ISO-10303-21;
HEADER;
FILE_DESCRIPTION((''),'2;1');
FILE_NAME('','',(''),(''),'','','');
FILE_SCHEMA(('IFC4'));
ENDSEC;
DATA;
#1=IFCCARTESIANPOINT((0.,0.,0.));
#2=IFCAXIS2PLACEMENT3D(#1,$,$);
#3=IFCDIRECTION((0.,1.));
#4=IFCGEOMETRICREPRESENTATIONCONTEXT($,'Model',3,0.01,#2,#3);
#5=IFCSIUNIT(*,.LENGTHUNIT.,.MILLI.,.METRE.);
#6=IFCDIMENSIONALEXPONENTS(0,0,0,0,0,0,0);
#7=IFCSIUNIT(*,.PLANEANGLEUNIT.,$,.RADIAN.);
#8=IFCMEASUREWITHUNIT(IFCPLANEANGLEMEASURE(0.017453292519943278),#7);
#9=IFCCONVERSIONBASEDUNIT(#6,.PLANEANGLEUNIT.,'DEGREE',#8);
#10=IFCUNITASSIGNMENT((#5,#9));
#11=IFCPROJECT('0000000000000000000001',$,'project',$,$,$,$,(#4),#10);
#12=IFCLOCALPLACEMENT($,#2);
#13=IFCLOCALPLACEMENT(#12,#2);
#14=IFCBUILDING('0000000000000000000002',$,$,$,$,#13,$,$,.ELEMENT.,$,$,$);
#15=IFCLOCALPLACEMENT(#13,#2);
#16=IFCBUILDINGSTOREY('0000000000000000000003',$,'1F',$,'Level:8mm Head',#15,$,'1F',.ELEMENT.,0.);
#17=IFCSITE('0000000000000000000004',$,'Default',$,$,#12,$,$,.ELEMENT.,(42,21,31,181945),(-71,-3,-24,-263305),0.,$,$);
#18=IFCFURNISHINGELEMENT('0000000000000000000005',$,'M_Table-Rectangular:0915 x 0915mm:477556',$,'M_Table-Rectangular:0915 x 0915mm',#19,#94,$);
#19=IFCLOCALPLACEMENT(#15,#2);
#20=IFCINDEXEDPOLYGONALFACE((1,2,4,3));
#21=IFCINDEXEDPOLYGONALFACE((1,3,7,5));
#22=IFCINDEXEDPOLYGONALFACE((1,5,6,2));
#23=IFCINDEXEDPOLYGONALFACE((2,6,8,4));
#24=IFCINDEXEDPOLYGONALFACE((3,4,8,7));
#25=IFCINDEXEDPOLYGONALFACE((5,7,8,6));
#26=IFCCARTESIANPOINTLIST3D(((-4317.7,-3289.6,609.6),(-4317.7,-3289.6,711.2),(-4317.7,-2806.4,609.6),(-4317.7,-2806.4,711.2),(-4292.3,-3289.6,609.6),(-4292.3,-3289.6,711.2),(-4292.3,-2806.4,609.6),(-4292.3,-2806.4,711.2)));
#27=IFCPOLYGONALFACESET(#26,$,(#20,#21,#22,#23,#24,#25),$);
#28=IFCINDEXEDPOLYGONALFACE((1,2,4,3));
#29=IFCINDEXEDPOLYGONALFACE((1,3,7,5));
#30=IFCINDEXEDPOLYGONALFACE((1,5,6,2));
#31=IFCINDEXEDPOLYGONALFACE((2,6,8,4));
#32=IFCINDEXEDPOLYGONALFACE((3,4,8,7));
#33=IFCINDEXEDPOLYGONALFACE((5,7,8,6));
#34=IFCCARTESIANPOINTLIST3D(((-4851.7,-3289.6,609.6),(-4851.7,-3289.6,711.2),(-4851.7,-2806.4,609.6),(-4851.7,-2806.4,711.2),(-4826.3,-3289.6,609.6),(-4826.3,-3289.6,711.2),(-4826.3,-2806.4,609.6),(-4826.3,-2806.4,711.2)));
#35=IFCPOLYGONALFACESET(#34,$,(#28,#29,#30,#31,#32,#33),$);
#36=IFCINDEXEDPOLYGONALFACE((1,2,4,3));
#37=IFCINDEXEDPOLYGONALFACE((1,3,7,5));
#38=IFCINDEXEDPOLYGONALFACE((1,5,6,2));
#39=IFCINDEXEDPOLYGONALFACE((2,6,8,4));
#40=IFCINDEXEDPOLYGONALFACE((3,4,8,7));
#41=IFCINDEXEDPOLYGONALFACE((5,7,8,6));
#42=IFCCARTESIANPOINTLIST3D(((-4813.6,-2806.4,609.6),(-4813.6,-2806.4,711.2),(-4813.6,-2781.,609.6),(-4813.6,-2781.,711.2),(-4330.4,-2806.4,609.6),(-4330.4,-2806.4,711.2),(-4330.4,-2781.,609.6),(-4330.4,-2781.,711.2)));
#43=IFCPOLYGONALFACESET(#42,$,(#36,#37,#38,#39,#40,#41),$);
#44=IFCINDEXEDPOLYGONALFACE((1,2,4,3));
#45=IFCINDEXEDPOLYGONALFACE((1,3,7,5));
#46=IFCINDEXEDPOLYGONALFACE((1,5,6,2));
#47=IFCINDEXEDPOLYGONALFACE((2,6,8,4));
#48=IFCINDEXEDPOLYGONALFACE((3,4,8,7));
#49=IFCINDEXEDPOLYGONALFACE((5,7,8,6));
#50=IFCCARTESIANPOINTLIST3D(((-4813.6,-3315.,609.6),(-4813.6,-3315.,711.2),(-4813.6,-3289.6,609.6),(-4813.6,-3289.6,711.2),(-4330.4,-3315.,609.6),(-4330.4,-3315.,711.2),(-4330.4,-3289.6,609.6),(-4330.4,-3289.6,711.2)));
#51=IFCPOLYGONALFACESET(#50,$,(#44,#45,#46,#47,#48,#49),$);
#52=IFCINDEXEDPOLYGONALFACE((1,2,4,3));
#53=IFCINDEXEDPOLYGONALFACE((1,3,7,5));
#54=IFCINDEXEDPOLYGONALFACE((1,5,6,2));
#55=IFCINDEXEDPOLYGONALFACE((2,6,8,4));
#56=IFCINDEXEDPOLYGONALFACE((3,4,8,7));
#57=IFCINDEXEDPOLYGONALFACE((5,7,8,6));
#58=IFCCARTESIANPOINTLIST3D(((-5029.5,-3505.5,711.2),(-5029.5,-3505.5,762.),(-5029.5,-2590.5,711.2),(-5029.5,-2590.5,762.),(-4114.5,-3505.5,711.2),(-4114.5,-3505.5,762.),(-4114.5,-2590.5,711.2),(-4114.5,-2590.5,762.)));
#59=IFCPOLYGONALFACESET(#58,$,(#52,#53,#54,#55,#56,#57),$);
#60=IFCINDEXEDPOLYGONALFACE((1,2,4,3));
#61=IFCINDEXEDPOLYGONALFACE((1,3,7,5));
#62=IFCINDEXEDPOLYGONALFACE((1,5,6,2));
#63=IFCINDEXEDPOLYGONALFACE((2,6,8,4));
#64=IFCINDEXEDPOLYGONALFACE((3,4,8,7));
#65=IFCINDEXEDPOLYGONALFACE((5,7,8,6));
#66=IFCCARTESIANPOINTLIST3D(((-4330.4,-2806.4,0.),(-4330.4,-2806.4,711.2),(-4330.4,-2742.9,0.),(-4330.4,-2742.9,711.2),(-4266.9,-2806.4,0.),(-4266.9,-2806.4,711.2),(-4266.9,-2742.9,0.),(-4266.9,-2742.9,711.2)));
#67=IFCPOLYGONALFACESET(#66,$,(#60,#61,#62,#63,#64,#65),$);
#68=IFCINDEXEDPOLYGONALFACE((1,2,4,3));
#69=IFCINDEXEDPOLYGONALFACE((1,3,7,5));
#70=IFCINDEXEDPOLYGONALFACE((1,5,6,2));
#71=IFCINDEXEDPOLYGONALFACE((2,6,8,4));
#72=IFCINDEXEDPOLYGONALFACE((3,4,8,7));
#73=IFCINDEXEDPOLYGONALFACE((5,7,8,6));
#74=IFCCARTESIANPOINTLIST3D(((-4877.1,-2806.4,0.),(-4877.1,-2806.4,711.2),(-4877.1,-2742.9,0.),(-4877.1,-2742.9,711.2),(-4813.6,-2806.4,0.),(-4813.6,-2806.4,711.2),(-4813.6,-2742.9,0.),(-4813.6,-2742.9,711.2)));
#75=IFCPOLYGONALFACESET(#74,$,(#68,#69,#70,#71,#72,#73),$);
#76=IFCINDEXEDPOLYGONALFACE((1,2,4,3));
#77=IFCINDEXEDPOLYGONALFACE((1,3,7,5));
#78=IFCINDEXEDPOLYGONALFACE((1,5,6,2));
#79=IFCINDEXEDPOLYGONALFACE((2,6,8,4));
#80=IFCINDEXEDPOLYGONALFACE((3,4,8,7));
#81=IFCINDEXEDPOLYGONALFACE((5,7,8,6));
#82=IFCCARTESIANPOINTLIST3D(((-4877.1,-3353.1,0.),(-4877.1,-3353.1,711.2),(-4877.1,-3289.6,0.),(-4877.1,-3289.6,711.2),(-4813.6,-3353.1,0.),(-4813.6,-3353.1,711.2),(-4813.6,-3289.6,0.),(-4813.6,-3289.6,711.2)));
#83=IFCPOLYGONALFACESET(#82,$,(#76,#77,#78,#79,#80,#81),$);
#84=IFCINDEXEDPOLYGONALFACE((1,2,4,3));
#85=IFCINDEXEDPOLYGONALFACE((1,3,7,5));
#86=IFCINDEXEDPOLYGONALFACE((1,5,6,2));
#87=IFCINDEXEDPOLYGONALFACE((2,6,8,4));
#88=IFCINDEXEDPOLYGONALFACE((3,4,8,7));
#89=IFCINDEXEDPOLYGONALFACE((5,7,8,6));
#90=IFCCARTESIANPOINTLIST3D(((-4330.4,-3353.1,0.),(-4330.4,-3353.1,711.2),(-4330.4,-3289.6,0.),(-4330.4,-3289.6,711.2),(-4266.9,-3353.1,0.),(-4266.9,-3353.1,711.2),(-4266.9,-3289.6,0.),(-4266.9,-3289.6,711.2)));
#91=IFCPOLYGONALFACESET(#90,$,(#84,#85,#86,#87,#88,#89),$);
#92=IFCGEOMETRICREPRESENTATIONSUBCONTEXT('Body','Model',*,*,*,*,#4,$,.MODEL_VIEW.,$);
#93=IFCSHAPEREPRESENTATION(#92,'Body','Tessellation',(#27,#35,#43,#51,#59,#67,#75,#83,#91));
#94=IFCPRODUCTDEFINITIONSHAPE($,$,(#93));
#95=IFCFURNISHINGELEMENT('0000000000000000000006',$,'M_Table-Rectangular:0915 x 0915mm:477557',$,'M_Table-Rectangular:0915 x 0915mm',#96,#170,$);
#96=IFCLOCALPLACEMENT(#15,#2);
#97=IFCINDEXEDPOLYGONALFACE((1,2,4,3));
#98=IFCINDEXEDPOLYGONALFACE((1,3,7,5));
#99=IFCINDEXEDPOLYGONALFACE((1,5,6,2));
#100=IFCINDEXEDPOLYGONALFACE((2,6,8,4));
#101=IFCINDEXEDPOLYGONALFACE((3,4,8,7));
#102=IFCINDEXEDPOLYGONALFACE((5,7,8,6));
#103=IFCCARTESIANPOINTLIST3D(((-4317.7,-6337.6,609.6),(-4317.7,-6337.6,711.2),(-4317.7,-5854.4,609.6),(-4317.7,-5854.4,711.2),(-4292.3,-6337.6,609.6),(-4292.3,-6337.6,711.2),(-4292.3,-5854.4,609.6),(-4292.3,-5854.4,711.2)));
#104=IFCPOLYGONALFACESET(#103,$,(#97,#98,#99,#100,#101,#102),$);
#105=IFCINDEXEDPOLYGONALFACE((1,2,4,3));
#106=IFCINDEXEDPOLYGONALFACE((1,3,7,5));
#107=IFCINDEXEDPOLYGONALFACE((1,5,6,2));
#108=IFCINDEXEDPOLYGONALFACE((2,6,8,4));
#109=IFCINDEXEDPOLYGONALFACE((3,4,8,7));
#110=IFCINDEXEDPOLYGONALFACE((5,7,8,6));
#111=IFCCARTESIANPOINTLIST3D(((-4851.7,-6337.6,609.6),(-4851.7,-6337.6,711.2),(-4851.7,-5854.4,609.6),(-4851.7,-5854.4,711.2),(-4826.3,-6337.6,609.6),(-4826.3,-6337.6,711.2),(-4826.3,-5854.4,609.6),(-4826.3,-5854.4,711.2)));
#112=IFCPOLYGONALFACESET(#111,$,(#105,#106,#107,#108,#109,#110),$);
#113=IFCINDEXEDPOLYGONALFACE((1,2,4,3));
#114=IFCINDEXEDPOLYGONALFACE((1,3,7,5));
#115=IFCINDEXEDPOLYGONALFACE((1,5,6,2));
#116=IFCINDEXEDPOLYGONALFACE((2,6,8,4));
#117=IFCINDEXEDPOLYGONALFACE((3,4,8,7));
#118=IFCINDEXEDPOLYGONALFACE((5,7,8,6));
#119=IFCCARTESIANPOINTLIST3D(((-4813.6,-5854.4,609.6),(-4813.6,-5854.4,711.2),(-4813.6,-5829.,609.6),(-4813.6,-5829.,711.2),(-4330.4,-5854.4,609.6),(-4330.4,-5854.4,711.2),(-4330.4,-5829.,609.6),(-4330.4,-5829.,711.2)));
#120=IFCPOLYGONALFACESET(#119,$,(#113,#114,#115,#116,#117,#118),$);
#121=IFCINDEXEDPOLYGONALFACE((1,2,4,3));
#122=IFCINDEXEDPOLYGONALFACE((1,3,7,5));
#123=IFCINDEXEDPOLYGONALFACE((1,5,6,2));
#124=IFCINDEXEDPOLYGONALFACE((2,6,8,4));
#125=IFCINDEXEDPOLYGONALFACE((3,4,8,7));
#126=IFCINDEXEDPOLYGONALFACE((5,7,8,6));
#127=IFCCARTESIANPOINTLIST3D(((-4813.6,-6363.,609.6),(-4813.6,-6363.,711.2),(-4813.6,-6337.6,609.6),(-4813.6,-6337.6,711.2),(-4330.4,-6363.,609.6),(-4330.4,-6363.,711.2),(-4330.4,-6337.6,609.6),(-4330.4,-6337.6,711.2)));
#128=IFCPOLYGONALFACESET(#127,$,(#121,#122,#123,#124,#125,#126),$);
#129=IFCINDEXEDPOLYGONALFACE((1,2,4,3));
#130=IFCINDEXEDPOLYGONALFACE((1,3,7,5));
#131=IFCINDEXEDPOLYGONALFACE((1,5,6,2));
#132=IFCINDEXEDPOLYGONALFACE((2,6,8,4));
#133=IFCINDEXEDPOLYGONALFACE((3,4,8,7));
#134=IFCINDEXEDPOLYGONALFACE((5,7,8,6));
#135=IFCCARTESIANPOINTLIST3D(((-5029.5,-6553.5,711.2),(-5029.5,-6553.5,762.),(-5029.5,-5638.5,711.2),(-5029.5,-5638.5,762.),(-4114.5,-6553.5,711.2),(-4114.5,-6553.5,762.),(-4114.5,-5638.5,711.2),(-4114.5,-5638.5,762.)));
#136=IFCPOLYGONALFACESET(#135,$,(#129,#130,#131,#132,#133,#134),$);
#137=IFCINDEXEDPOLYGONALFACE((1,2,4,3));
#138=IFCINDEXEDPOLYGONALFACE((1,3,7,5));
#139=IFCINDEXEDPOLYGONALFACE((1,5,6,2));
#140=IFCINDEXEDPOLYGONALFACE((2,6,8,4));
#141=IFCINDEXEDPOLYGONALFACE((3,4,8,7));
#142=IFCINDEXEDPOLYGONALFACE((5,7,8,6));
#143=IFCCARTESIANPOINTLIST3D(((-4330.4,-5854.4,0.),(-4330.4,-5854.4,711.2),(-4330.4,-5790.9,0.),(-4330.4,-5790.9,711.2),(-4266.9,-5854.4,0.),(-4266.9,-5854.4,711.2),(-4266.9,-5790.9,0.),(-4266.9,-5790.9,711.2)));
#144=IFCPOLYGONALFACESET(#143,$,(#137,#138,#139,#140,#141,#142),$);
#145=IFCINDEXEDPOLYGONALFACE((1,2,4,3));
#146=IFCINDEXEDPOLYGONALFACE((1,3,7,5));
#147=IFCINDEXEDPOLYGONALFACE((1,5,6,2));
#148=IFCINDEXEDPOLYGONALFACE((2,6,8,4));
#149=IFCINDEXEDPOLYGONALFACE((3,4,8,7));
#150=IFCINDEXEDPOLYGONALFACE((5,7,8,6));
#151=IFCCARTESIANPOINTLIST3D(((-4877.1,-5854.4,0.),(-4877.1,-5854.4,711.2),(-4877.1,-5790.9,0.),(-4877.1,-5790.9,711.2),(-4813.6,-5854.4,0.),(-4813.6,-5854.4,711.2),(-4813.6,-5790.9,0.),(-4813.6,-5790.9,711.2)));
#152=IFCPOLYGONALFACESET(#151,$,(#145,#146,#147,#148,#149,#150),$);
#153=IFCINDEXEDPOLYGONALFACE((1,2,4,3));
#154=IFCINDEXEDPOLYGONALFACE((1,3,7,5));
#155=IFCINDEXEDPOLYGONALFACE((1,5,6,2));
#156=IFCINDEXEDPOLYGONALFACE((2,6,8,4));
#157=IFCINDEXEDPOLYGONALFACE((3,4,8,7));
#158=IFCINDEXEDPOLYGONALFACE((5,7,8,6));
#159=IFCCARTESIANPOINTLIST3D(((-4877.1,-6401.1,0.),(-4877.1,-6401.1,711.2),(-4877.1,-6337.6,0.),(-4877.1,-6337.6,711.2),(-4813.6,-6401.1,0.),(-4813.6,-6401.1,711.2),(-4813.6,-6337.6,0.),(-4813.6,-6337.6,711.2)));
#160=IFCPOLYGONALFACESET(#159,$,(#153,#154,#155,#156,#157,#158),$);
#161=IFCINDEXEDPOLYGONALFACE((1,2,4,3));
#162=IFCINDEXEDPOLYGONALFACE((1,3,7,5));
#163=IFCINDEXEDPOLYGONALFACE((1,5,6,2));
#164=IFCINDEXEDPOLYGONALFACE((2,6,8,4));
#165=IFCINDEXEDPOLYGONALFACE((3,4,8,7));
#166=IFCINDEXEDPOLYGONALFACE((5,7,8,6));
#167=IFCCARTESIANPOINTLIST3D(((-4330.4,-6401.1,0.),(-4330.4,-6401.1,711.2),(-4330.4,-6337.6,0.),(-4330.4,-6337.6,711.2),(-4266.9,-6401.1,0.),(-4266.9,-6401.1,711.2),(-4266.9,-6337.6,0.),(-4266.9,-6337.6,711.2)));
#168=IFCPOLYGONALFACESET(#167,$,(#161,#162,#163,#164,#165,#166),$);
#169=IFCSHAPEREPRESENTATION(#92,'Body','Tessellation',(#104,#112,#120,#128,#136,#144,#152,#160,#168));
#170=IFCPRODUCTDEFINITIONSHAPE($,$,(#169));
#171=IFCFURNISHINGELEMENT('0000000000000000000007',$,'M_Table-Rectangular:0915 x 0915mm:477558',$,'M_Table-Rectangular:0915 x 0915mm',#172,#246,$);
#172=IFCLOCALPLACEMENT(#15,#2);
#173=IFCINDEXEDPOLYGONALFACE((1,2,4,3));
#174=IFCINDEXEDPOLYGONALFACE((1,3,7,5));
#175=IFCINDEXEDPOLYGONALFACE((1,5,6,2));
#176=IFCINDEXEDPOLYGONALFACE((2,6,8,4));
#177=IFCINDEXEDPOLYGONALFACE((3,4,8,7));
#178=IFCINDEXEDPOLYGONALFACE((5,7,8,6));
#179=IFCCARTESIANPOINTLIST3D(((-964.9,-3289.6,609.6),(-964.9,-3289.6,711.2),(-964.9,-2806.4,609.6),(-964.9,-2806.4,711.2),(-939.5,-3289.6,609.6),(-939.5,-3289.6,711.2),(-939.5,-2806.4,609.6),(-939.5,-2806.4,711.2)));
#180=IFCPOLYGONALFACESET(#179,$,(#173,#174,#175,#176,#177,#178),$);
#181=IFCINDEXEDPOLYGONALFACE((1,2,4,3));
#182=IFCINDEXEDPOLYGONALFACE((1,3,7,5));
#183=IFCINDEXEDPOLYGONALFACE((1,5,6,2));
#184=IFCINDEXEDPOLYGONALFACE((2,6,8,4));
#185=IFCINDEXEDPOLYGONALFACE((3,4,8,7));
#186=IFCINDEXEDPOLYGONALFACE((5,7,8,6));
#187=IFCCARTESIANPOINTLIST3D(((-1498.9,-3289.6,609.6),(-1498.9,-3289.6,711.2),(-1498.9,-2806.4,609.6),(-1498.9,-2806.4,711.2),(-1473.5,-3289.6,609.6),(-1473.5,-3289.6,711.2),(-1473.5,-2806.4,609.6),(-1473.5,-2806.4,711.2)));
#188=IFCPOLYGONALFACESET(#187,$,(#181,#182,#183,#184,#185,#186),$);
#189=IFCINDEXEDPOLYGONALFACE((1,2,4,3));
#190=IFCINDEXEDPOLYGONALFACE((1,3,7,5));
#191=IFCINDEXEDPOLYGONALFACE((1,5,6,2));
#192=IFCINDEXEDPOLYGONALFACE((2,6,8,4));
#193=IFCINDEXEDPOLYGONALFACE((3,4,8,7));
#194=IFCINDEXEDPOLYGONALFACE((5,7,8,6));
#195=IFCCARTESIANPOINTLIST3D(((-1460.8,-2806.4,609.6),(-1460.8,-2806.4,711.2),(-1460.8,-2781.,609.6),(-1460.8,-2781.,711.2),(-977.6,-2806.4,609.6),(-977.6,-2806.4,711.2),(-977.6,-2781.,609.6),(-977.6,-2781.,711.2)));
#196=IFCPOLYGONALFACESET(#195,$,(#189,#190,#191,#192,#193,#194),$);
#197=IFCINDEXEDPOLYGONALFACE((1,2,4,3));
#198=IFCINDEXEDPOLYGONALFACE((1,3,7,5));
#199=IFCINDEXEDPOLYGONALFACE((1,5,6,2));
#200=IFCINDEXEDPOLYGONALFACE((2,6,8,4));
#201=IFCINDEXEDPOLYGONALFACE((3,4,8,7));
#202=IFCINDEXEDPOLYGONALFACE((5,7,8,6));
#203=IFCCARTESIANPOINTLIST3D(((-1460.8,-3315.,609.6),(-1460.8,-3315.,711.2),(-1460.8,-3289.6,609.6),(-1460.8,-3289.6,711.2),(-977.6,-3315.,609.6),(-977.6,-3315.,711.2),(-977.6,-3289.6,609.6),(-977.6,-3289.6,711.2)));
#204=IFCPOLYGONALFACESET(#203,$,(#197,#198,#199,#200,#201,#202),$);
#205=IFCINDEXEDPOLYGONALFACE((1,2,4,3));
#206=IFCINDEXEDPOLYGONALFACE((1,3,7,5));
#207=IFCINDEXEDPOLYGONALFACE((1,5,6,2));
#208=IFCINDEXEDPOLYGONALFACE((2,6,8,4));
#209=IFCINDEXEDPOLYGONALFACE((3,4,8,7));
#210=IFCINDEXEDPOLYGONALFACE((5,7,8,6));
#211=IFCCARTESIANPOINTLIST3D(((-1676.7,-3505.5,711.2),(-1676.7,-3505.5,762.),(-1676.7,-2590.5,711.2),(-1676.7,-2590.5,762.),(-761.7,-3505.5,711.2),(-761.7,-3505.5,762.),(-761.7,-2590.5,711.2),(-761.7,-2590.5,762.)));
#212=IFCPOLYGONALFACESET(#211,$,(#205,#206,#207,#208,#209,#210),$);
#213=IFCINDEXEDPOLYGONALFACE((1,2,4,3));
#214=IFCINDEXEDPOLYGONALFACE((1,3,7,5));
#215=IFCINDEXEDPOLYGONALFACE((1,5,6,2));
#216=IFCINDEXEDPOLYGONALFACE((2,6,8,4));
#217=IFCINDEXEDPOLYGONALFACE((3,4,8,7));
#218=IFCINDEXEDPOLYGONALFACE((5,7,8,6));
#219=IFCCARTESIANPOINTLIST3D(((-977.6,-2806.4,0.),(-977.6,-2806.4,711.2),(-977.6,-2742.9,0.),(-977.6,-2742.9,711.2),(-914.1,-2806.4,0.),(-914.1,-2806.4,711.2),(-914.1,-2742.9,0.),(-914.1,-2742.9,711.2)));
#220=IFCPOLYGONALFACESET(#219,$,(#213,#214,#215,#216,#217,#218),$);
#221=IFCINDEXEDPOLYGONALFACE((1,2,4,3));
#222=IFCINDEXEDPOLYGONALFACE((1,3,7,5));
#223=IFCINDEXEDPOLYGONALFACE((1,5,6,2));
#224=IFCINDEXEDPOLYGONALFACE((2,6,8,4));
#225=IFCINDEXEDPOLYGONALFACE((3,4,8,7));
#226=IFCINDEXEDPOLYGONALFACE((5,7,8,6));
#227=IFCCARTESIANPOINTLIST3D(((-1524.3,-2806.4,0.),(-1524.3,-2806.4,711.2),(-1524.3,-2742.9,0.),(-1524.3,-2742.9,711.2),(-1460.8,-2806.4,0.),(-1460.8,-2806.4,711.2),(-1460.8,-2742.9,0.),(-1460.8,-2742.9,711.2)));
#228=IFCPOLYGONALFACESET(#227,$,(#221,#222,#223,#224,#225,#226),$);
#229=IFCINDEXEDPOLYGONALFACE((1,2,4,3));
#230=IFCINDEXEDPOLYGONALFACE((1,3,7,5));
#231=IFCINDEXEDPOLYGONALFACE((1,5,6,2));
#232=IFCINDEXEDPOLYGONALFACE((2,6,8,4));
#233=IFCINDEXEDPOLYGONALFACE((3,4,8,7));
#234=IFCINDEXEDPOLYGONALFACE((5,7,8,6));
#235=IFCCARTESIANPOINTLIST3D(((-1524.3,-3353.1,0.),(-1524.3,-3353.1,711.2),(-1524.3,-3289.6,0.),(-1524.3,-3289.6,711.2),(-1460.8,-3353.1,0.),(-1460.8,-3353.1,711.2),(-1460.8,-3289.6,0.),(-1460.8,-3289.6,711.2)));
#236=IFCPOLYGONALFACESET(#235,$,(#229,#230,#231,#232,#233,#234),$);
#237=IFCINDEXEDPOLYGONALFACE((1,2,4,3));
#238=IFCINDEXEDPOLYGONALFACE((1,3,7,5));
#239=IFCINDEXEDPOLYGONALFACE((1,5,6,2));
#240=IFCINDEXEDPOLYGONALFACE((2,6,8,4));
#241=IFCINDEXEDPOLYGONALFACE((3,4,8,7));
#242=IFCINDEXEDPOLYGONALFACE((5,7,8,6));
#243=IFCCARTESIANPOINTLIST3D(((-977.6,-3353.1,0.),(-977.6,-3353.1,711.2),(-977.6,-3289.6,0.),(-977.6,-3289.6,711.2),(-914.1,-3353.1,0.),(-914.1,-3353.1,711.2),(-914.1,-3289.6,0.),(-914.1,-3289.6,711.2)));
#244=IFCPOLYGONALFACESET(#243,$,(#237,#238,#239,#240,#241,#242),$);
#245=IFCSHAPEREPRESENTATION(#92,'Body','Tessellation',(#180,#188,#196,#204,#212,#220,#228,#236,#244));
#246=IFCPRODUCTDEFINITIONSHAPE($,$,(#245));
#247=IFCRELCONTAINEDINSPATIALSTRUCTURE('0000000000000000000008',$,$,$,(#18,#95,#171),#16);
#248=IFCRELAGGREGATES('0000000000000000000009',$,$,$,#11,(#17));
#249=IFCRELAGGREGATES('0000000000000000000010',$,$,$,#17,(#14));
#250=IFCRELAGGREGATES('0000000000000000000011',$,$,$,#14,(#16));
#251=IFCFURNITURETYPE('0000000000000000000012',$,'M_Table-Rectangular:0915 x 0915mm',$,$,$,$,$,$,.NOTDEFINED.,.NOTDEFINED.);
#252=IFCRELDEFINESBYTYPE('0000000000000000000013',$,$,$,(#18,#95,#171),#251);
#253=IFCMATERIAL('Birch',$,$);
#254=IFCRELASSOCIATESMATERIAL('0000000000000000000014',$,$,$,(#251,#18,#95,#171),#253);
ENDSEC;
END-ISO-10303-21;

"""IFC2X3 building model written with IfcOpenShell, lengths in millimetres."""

from ifc_helpers import new_model, entity, si_unit, converted_unit, direction, frame, frame_2d, origin, origin_2d_with_axis, place, context, subcontext, project, spatial, rectangle, extrude, source, transform, mapped, material, type_object, type_shapes, element, save


model = new_model("IFC2X3")

# Units and contexts
model_context = context("Model", 3, precision=0.01, world=origin(), true_north=direction((0.0, 1.0)))
body_context = subcontext(model_context, "Body", "Model", "MODEL_VIEW")
ifc_project = project(units=[si_unit("LENGTHUNIT", "METRE", prefix="MILLI"), converted_unit("PLANEANGLEUNIT", "DEGREE", entity("IfcPlaneAngleMeasure", 0.017453292519943278), si_unit("PLANEANGLEUNIT", "RADIAN"), dimensions=[0, 0, 0, 0, 0, 0, 0])], contexts=[model_context])

# Site, building, storey
site_placement = place(None, origin())
site = spatial("IfcSite", under=ifc_project, at=site_placement, Name="Default", CompositionType="ELEMENT", RefLatitude=(42, 21, 31, 181945), RefLongitude=(-71, -3, -24, -263305), RefElevation=0.0)
building_placement = place(site_placement, origin())
building = spatial("IfcBuilding", under=site, at=building_placement, CompositionType="ELEMENT")
storey_placement = place(building_placement, origin())
storey = spatial("IfcBuildingStorey", under=building, at=storey_placement, Name="1F", ObjectType="Level:8mm Head", LongName="1F", CompositionType="ELEMENT", Elevation=0.0)

# Furnishing elements
ifc_material_1 = material(Name="Birch")
furniture_type_1 = type_object("IfcFurnitureType", Name="M_Table-Rectangular:0915 x 0915mm", AssemblyPlace="NOTDEFINED", material=ifc_material_1)
shared_shape_1 = source(origin(), body_context, "Body", "SweptSolid", [
    extrude(rectangle(XDim=25.4, YDim=483.2, at=origin_2d_with_axis()), frame((267.0, 0.0, 609.6)), (0.0, 0.0, 1.0), 101.6),
    extrude(rectangle(XDim=483.2, YDim=25.4, at=origin_2d_with_axis()), frame((-267.0, 0.0, 609.6), z_axis=(0.0, 0.0, 1.0), x_axis=(0.0, 1.0, 0.0)), (0.0, 0.0, 1.0), 101.6),
    extrude(rectangle(XDim=483.2, YDim=25.4, at=frame_2d((0.0, 0.0), x_axis=(1.0, 0.0))), frame((0.0, 254.3, 609.6), z_axis=(0.0, 0.0, 1.0), x_axis=(-1.0, 0.0, 0.0)), (0.0, 0.0, 1.0), 101.6),
    extrude(rectangle(XDim=25.4, YDim=483.2, at=origin_2d_with_axis()), frame((0.0, -254.3, 609.6), z_axis=(0.0, 0.0, 1.0), x_axis=(0.0, 1.0, 0.0)), (0.0, 0.0, 1.0), 101.6),
    extrude(rectangle(XDim=915.0, YDim=915.0, at=origin_2d_with_axis()), frame((0.0, 0.0, 711.2), z_axis=(0.0, 0.0, 1.0), x_axis=(-1.0, 0.0, 0.0)), (0.0, 0.0, 1.0), 50.8),
    extrude(rectangle(XDim=63.5, YDim=63.5, at=origin_2d_with_axis()), frame((273.3, 273.4, 0.0), z_axis=(0.0, 0.0, 1.0), x_axis=(0.0, -1.0, 0.0)), (0.0, 0.0, 1.0), 711.2),
    extrude(rectangle(XDim=63.5, YDim=63.5, at=origin_2d_with_axis()), frame((-273.3, 273.4, 0.0), z_axis=(0.0, 0.0, 1.0), x_axis=(-1.0, 0.0, 0.0)), (0.0, 0.0, 1.0), 711.2),
    extrude(rectangle(XDim=63.5, YDim=63.5, at=origin_2d_with_axis()), frame((-273.3, -273.4, 0.0), z_axis=(0.0, 0.0, 1.0), x_axis=(0.0, 1.0, 0.0)), (0.0, 0.0, 1.0), 711.2),
    extrude(rectangle(XDim=63.5, YDim=63.5, at=origin_2d_with_axis()), frame((273.3, -273.4, 0.0)), (0.0, 0.0, 1.0), 711.2),
])
type_shapes(furniture_type_1, [shared_shape_1])
for number, where, name in (
    (1, (-4572.0, -3048.0, 0.0), "M_Table-Rectangular:0915 x 0915mm:477556"),
    (2, (-4572.0, -6096.0, 0.0), "M_Table-Rectangular:0915 x 0915mm:477557"),
    (3, (-1219.2, -3048.0, 0.0), "M_Table-Rectangular:0915 x 0915mm:477558"),
):
    element("IfcFurnishingElement", number, at=place(storey_placement, frame(where)), inside=storey, type_object=furniture_type_1, material=ifc_material_1, Name=name, ObjectType="M_Table-Rectangular:0915 x 0915mm", context=body_context, shape_type="MappedRepresentation", body=[
        mapped(shared_shape_1, transform((0.0, 0.0, 0.0), scale=1.0)),
    ])

save(model, "model.ifc")
